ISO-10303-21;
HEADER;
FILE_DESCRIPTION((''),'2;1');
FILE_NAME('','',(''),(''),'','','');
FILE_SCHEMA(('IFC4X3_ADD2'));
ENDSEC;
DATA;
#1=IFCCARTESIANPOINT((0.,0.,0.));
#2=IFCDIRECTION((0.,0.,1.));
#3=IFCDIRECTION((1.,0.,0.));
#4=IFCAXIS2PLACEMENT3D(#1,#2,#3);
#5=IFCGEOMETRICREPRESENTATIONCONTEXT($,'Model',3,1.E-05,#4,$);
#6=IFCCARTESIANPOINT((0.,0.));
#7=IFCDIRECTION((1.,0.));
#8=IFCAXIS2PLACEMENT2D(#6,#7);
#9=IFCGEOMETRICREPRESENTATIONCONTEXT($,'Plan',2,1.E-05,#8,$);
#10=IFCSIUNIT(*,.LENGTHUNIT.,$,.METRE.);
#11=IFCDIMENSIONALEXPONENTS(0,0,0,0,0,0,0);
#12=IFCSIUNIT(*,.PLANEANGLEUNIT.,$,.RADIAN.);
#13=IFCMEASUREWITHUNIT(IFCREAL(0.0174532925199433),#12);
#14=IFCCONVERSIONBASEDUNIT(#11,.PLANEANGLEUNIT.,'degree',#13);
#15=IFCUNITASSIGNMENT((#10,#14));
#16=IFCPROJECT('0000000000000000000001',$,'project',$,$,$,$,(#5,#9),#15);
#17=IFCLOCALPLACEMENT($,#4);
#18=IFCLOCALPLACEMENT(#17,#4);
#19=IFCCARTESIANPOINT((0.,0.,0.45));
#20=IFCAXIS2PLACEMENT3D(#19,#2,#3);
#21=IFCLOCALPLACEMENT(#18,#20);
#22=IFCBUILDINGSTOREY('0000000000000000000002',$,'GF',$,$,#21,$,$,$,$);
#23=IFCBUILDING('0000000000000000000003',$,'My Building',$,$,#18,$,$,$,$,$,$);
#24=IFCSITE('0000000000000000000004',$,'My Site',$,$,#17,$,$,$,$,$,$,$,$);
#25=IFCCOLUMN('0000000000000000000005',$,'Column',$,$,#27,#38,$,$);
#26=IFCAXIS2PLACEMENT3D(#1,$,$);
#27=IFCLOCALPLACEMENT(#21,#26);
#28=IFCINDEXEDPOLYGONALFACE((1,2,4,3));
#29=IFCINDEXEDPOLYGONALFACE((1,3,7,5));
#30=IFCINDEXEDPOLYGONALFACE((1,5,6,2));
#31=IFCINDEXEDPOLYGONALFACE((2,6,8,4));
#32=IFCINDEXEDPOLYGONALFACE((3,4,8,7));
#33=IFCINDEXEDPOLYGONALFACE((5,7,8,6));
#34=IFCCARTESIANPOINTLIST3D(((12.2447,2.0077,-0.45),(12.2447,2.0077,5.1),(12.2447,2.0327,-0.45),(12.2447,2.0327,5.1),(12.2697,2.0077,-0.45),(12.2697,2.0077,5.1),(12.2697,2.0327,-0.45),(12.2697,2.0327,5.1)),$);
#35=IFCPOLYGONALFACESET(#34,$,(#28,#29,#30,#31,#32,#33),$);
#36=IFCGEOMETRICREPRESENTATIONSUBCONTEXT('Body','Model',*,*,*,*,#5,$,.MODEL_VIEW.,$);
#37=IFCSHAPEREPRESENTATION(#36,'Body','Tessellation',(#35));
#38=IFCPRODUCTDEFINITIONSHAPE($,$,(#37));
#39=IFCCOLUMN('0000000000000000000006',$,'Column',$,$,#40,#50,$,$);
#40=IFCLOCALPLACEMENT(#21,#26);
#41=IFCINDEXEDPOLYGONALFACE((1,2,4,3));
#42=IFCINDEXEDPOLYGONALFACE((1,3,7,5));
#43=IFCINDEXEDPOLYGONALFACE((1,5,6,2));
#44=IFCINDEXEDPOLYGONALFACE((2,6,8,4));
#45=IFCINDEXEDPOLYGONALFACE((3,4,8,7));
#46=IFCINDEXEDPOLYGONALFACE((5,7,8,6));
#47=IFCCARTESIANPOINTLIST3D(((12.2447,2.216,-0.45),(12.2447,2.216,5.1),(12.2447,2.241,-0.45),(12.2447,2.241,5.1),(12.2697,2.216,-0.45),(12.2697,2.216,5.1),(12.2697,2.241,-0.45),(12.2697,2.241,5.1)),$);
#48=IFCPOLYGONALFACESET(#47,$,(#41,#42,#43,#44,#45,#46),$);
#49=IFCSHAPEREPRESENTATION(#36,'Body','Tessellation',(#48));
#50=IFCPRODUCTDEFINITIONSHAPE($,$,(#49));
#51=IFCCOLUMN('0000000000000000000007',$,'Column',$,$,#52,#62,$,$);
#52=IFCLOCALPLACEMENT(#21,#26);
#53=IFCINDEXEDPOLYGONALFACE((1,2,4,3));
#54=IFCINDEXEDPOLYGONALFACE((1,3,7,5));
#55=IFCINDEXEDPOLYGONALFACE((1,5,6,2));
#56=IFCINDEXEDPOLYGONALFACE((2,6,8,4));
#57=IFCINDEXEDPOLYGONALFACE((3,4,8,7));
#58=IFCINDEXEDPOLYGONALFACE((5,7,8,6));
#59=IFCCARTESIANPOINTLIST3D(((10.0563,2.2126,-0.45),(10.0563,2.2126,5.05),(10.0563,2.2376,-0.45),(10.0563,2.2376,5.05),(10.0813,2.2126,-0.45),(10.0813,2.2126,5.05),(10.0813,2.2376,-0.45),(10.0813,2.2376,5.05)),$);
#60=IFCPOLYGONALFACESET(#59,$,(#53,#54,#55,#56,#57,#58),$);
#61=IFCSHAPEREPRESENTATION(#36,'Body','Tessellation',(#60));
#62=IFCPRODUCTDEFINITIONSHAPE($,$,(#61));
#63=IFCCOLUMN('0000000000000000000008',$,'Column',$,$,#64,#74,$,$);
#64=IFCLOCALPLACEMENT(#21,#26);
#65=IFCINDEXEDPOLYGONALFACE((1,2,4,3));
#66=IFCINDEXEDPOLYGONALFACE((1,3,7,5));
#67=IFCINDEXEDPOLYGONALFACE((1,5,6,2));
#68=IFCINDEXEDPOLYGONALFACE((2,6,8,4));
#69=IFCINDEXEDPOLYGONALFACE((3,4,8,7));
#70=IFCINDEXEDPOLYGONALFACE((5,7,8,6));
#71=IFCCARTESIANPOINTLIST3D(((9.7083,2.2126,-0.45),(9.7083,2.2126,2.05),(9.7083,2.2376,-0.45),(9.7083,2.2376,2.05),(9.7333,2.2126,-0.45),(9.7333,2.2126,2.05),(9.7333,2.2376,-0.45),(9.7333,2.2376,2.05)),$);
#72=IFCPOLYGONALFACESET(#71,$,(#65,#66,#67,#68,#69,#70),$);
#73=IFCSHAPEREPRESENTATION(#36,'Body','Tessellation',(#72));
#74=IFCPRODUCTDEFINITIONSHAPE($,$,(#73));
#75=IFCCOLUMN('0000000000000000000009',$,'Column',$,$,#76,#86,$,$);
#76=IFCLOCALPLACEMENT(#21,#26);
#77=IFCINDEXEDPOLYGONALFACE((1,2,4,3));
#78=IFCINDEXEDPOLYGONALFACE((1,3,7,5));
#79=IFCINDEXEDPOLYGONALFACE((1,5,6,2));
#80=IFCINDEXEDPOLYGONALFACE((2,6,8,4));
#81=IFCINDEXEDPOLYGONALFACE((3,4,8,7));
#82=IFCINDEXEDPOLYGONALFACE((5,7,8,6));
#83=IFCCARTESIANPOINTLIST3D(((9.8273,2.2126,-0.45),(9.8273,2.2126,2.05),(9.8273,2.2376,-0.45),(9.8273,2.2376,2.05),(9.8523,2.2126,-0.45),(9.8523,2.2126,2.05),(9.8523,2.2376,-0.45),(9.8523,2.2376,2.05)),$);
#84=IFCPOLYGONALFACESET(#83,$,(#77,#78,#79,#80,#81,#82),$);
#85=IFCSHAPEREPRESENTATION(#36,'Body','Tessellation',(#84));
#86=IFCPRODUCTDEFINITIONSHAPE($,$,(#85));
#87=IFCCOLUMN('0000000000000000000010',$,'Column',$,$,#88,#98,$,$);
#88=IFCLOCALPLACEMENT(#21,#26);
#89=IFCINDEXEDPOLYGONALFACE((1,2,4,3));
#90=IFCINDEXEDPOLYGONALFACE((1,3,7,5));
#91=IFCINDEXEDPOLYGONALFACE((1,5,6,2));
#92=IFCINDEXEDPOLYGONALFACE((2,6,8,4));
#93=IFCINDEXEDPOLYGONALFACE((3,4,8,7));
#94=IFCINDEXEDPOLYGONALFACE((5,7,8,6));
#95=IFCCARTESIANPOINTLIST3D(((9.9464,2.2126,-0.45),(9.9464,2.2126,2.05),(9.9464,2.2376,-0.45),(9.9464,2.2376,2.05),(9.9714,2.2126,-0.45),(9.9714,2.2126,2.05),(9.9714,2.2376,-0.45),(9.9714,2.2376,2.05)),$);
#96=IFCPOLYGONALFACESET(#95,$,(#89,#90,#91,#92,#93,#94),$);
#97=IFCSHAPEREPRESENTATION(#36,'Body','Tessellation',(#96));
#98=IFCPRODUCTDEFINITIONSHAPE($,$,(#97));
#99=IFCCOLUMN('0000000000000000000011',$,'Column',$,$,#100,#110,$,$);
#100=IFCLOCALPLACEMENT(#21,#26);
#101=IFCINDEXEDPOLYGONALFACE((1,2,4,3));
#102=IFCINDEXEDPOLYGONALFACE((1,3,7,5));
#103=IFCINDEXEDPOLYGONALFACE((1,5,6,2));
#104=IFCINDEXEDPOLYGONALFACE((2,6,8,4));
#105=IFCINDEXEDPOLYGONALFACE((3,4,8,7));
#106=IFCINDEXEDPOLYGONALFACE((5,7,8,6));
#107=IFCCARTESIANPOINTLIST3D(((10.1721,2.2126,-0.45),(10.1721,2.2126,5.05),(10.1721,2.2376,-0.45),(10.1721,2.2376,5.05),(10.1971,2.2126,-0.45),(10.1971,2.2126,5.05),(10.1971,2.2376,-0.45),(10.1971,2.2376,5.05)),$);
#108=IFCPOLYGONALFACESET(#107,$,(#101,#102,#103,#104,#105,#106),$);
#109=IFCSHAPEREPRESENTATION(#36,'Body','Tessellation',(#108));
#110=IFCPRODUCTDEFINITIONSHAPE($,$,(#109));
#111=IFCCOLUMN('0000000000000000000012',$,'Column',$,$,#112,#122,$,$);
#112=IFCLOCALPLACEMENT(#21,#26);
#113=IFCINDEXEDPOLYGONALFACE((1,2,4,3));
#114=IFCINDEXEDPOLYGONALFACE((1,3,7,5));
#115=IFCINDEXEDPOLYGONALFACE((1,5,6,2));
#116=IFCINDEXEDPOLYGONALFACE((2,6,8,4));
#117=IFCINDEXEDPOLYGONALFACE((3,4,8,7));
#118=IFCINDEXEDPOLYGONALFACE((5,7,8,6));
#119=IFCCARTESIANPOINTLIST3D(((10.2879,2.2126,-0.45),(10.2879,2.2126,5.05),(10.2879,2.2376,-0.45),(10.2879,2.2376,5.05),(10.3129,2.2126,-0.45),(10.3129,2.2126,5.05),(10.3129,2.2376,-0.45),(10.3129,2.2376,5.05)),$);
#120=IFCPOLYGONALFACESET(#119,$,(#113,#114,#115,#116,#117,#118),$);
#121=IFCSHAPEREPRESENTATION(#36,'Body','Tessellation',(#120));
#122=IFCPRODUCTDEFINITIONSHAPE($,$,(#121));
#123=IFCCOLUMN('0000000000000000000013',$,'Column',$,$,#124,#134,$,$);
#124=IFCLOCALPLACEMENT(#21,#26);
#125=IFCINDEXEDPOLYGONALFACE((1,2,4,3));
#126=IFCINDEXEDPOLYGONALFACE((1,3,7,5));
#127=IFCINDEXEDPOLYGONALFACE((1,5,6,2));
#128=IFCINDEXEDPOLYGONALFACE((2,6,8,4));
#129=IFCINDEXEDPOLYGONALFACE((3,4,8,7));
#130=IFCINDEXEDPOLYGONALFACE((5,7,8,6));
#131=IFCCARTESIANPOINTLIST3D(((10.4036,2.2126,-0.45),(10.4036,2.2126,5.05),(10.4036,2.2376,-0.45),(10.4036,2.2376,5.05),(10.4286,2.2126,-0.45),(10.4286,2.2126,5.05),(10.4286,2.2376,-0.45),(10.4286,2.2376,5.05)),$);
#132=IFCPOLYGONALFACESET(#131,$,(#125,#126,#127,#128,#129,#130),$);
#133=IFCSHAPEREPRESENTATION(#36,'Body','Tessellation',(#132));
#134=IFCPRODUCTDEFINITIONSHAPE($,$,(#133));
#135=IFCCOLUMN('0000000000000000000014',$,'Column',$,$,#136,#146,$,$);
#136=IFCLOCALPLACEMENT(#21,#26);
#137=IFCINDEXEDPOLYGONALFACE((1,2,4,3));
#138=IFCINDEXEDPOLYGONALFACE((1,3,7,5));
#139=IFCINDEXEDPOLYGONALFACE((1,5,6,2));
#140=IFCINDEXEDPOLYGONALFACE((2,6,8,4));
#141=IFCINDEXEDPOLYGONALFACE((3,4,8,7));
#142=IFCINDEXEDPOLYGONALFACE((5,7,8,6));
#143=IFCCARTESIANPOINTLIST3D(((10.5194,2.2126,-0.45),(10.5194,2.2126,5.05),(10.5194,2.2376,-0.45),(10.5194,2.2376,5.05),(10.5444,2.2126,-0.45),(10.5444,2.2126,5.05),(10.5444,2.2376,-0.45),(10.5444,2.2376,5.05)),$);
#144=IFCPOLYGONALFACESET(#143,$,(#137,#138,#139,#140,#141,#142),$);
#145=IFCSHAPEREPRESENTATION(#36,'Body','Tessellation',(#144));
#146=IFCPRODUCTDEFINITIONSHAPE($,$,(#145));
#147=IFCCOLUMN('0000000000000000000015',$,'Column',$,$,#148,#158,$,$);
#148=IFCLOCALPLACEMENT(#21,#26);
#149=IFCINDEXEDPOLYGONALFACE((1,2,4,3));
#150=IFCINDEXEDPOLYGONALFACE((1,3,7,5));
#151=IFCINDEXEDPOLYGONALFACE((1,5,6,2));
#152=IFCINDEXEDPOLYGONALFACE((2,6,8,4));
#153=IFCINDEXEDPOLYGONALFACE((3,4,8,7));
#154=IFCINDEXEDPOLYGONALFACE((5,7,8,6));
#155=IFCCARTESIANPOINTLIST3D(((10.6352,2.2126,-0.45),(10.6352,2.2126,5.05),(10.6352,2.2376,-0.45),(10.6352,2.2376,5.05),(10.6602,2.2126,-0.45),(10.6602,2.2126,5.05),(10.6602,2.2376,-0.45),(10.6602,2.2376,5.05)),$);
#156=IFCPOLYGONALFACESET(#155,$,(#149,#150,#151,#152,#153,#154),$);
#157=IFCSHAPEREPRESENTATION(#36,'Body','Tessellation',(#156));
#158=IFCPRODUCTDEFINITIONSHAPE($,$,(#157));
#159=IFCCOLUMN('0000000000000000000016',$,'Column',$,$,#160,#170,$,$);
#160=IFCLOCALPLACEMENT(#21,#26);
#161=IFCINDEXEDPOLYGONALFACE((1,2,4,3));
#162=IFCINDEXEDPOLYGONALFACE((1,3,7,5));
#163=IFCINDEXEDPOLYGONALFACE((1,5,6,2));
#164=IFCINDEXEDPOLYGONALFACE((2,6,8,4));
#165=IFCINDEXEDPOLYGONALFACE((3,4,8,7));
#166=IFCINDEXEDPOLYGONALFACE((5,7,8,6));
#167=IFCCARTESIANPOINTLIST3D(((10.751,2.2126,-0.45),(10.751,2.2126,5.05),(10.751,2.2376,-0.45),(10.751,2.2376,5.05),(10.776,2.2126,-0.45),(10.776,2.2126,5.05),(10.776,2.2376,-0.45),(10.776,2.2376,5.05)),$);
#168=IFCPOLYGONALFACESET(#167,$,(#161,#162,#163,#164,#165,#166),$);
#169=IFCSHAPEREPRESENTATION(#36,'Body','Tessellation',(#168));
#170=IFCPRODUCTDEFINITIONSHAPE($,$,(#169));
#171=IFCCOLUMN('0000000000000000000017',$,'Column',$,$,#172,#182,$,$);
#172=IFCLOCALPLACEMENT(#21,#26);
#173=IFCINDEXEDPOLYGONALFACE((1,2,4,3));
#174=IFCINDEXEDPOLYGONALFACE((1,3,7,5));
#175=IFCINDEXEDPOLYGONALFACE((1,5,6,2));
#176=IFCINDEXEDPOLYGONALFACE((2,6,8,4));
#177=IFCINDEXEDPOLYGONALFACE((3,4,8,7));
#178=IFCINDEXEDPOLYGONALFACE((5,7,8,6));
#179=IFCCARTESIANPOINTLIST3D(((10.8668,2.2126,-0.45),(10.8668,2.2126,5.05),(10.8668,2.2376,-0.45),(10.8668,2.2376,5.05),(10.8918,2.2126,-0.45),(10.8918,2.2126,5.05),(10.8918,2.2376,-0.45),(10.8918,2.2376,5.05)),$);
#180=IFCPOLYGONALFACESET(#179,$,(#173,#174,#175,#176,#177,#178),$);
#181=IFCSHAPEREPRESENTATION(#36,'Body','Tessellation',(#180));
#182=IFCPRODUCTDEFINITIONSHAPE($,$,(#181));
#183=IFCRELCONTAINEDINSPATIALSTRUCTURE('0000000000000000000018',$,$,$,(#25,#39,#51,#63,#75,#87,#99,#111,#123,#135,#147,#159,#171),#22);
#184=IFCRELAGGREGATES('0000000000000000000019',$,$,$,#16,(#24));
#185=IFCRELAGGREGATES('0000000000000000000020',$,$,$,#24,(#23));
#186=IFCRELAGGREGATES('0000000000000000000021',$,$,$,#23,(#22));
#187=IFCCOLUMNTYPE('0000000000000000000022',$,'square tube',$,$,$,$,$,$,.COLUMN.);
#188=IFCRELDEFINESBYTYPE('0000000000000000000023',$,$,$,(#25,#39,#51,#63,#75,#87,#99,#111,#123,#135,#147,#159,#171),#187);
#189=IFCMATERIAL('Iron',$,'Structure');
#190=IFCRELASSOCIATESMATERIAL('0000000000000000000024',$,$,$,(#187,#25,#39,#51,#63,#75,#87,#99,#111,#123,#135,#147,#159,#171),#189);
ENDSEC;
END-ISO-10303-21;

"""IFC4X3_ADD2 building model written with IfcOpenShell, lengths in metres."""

from ifc_helpers import new_model, entity, si_unit, converted_unit, frame, origin_with_axes, origin_2d_with_axis, place, context, subcontext, project, spatial, indexed_curve, outline, extrude, material, material_profile, profile_set, profile_usage, type_object, element, save


model = new_model("IFC4X3_ADD2")

# Units and contexts
model_context = context("Model", 3, precision=1e-05, world=origin_with_axes())
plan_context = context("Plan", 2, precision=1e-05, world=origin_2d_with_axis())
body_context_1 = subcontext(model_context, "Body", "Model", "MODEL_VIEW")
ifc_project = project(units=[si_unit("LENGTHUNIT", "METRE"), converted_unit("PLANEANGLEUNIT", "degree", entity("IfcReal", 0.0174532925199433), si_unit("PLANEANGLEUNIT", "RADIAN"), dimensions=[0, 0, 0, 0, 0, 0, 0])], contexts=[model_context, plan_context])

# Site, building, storey
site_placement = place(None, origin_with_axes())
site = spatial("IfcSite", under=ifc_project, at=site_placement, Name="My Site")
building_placement = place(site_placement, origin_with_axes())
building = spatial("IfcBuilding", under=site, at=building_placement, Name="My Building")
storey_placement = place(building_placement, frame((0.0, 0.0, 0.45), z_axis=(0.0, 0.0, 1.0), x_axis=(1.0, 0.0, 0.0)))
storey = spatial("IfcBuildingStorey", under=building, at=storey_placement, Name="GF")

# Columns
ifc_material_1 = material(Name="Iron", Category="Structure")
ifc_material_profile = material_profile(ifc_material_1, outline(indexed_curve([(-0.0125, -0.0125), (0.0125, -0.0125), (0.0125, 0.0125), (-0.0125, 0.0125), (-0.0125, -0.0125)])))
ifc_profile_set = profile_set([ifc_material_profile])
ifc_profile_usage_1 = profile_usage(ifc_profile_set, cardinal=5)
column_type = type_object("IfcColumnType", Name="square tube", PredefinedType="COLUMN", material=ifc_profile_set)
column_1_placement = place(storey_placement, frame((12.2572, 2.0202, -0.45), z_axis=(0.0, 0.0, 1.0), x_axis=(0.0, 1.0, 0.0)))
element("IfcColumn", 1, at=column_1_placement, inside=storey, type_object=column_type, material=ifc_profile_usage_1, Name="Column", context=body_context_1, shape_type="SweptSolid", body=[
    extrude(outline(indexed_curve([(-0.0125, -0.0125), (0.0125, -0.0125), (0.0125, 0.0125), (-0.0125, 0.0125), (-0.0125, -0.0125)])), origin_with_axes(), (0.0, 0.0, 1.0), 5.55),
])
ifc_profile_usage_2 = profile_usage(ifc_profile_set, cardinal=5)
column_2_placement = place(storey_placement, frame((12.2572, 2.2285, -0.45), z_axis=(0.0, 0.0, 1.0), x_axis=(0.0, 1.0, 0.0)))
element("IfcColumn", 2, at=column_2_placement, inside=storey, type_object=column_type, material=ifc_profile_usage_2, Name="Column", context=body_context_1, shape_type="SweptSolid", body=[
    extrude(outline(indexed_curve([(-0.0125, -0.0125), (0.0125, -0.0125), (0.0125, 0.0125), (-0.0125, 0.0125), (-0.0125, -0.0125)])), origin_with_axes(), (0.0, 0.0, 1.0), 5.55),
])
ifc_profile_usage_3 = profile_usage(ifc_profile_set, cardinal=5)
column_3_placement = place(storey_placement, frame((10.0688, 2.2251, -0.45), z_axis=(0.0, 0.0, 1.0), x_axis=(1.0, 0.0, 0.0)))
element("IfcColumn", 3, at=column_3_placement, inside=storey, type_object=column_type, material=ifc_profile_usage_3, Name="Column", context=body_context_1, shape_type="SweptSolid", body=[
    extrude(outline(indexed_curve([(-0.0125, -0.0125), (0.0125, -0.0125), (0.0125, 0.0125), (-0.0125, 0.0125), (-0.0125, -0.0125)])), origin_with_axes(), (0.0, 0.0, 1.0), 5.5),
])
ifc_profile_usage_4 = profile_usage(ifc_profile_set, cardinal=5)
column_4_placement = place(storey_placement, frame((9.7208, 2.2251, -0.45), z_axis=(0.0, 0.0, 1.0), x_axis=(1.0, 0.0, 0.0)))
element("IfcColumn", 4, at=column_4_placement, inside=storey, type_object=column_type, material=ifc_profile_usage_4, Name="Column", context=body_context_1, shape_type="SweptSolid", body=[
    extrude(outline(indexed_curve([(-0.0125, -0.0125), (0.0125, -0.0125), (0.0125, 0.0125), (-0.0125, 0.0125), (-0.0125, -0.0125)])), origin_with_axes(), (0.0, 0.0, 1.0), 2.5),
])
ifc_profile_usage_5 = profile_usage(ifc_profile_set, cardinal=5)
column_5_placement = place(storey_placement, frame((9.8398, 2.2251, -0.45), z_axis=(0.0, 0.0, 1.0), x_axis=(1.0, 0.0, 0.0)))
element("IfcColumn", 5, at=column_5_placement, inside=storey, type_object=column_type, material=ifc_profile_usage_5, Name="Column", context=body_context_1, shape_type="SweptSolid", body=[
    extrude(outline(indexed_curve([(-0.0125, -0.0125), (0.0125, -0.0125), (0.0125, 0.0125), (-0.0125, 0.0125), (-0.0125, -0.0125)])), origin_with_axes(), (0.0, 0.0, 1.0), 2.5),
])
ifc_profile_usage_6 = profile_usage(ifc_profile_set, cardinal=5)
column_6_placement = place(storey_placement, frame((9.9589, 2.2251, -0.45), z_axis=(0.0, 0.0, 1.0), x_axis=(1.0, 0.0, 0.0)))
element("IfcColumn", 6, at=column_6_placement, inside=storey, type_object=column_type, material=ifc_profile_usage_6, Name="Column", context=body_context_1, shape_type="SweptSolid", body=[
    extrude(outline(indexed_curve([(-0.0125, -0.0125), (0.0125, -0.0125), (0.0125, 0.0125), (-0.0125, 0.0125), (-0.0125, -0.0125)])), origin_with_axes(), (0.0, 0.0, 1.0), 2.5),
])
ifc_profile_usage_7 = profile_usage(ifc_profile_set, cardinal=5)
column_7_placement = place(storey_placement, frame((10.1846, 2.2251, -0.45), z_axis=(0.0, 0.0, 1.0), x_axis=(1.0, 0.0, 0.0)))
element("IfcColumn", 7, at=column_7_placement, inside=storey, type_object=column_type, material=ifc_profile_usage_7, Name="Column", context=body_context_1, shape_type="SweptSolid", body=[
    extrude(outline(indexed_curve([(-0.0125, -0.0125), (0.0125, -0.0125), (0.0125, 0.0125), (-0.0125, 0.0125), (-0.0125, -0.0125)])), origin_with_axes(), (0.0, 0.0, 1.0), 5.5),
])
ifc_profile_usage_8 = profile_usage(ifc_profile_set, cardinal=5)
column_8_placement = place(storey_placement, frame((10.3004, 2.2251, -0.45), z_axis=(0.0, 0.0, 1.0), x_axis=(1.0, 0.0, 0.0)))
element("IfcColumn", 8, at=column_8_placement, inside=storey, type_object=column_type, material=ifc_profile_usage_8, Name="Column", context=body_context_1, shape_type="SweptSolid", body=[
    extrude(outline(indexed_curve([(-0.0125, -0.0125), (0.0125, -0.0125), (0.0125, 0.0125), (-0.0125, 0.0125), (-0.0125, -0.0125)])), origin_with_axes(), (0.0, 0.0, 1.0), 5.5),
])
ifc_profile_usage_9 = profile_usage(ifc_profile_set, cardinal=5)
column_9_placement = place(storey_placement, frame((10.4161, 2.2251, -0.45), z_axis=(0.0, 0.0, 1.0), x_axis=(1.0, 0.0, 0.0)))
element("IfcColumn", 9, at=column_9_placement, inside=storey, type_object=column_type, material=ifc_profile_usage_9, Name="Column", context=body_context_1, shape_type="SweptSolid", body=[
    extrude(outline(indexed_curve([(-0.0125, -0.0125), (0.0125, -0.0125), (0.0125, 0.0125), (-0.0125, 0.0125), (-0.0125, -0.0125)])), origin_with_axes(), (0.0, 0.0, 1.0), 5.5),
])
ifc_profile_usage_10 = profile_usage(ifc_profile_set, cardinal=5)
column_10_placement = place(storey_placement, frame((10.5319, 2.2251, -0.45), z_axis=(0.0, 0.0, 1.0), x_axis=(1.0, 0.0, 0.0)))
element("IfcColumn", 10, at=column_10_placement, inside=storey, type_object=column_type, material=ifc_profile_usage_10, Name="Column", context=body_context_1, shape_type="SweptSolid", body=[
    extrude(outline(indexed_curve([(-0.0125, -0.0125), (0.0125, -0.0125), (0.0125, 0.0125), (-0.0125, 0.0125), (-0.0125, -0.0125)])), origin_with_axes(), (0.0, 0.0, 1.0), 5.5),
])
ifc_profile_usage_11 = profile_usage(ifc_profile_set, cardinal=5)
column_11_placement = place(storey_placement, frame((10.6477, 2.2251, -0.45), z_axis=(0.0, 0.0, 1.0), x_axis=(1.0, 0.0, 0.0)))
element("IfcColumn", 11, at=column_11_placement, inside=storey, type_object=column_type, material=ifc_profile_usage_11, Name="Column", context=body_context_1, shape_type="SweptSolid", body=[
    extrude(outline(indexed_curve([(-0.0125, -0.0125), (0.0125, -0.0125), (0.0125, 0.0125), (-0.0125, 0.0125), (-0.0125, -0.0125)])), origin_with_axes(), (0.0, 0.0, 1.0), 5.5),
])
ifc_profile_usage_12 = profile_usage(ifc_profile_set, cardinal=5)
column_12_placement = place(storey_placement, frame((10.7635, 2.2251, -0.45), z_axis=(0.0, 0.0, 1.0), x_axis=(1.0, 0.0, 0.0)))
element("IfcColumn", 12, at=column_12_placement, inside=storey, type_object=column_type, material=ifc_profile_usage_12, Name="Column", context=body_context_1, shape_type="SweptSolid", body=[
    extrude(outline(indexed_curve([(-0.0125, -0.0125), (0.0125, -0.0125), (0.0125, 0.0125), (-0.0125, 0.0125), (-0.0125, -0.0125)])), origin_with_axes(), (0.0, 0.0, 1.0), 5.5),
])
ifc_profile_usage_13 = profile_usage(ifc_profile_set, cardinal=5)
column_13_placement = place(storey_placement, frame((10.8793, 2.2251, -0.45), z_axis=(0.0, 0.0, 1.0), x_axis=(1.0, 0.0, 0.0)))
element("IfcColumn", 13, at=column_13_placement, inside=storey, type_object=column_type, material=ifc_profile_usage_13, Name="Column", context=body_context_1, shape_type="SweptSolid", body=[
    extrude(outline(indexed_curve([(-0.0125, -0.0125), (0.0125, -0.0125), (0.0125, 0.0125), (-0.0125, 0.0125), (-0.0125, -0.0125)])), origin_with_axes(), (0.0, 0.0, 1.0), 5.5),
])

save(model, "model.ifc")
